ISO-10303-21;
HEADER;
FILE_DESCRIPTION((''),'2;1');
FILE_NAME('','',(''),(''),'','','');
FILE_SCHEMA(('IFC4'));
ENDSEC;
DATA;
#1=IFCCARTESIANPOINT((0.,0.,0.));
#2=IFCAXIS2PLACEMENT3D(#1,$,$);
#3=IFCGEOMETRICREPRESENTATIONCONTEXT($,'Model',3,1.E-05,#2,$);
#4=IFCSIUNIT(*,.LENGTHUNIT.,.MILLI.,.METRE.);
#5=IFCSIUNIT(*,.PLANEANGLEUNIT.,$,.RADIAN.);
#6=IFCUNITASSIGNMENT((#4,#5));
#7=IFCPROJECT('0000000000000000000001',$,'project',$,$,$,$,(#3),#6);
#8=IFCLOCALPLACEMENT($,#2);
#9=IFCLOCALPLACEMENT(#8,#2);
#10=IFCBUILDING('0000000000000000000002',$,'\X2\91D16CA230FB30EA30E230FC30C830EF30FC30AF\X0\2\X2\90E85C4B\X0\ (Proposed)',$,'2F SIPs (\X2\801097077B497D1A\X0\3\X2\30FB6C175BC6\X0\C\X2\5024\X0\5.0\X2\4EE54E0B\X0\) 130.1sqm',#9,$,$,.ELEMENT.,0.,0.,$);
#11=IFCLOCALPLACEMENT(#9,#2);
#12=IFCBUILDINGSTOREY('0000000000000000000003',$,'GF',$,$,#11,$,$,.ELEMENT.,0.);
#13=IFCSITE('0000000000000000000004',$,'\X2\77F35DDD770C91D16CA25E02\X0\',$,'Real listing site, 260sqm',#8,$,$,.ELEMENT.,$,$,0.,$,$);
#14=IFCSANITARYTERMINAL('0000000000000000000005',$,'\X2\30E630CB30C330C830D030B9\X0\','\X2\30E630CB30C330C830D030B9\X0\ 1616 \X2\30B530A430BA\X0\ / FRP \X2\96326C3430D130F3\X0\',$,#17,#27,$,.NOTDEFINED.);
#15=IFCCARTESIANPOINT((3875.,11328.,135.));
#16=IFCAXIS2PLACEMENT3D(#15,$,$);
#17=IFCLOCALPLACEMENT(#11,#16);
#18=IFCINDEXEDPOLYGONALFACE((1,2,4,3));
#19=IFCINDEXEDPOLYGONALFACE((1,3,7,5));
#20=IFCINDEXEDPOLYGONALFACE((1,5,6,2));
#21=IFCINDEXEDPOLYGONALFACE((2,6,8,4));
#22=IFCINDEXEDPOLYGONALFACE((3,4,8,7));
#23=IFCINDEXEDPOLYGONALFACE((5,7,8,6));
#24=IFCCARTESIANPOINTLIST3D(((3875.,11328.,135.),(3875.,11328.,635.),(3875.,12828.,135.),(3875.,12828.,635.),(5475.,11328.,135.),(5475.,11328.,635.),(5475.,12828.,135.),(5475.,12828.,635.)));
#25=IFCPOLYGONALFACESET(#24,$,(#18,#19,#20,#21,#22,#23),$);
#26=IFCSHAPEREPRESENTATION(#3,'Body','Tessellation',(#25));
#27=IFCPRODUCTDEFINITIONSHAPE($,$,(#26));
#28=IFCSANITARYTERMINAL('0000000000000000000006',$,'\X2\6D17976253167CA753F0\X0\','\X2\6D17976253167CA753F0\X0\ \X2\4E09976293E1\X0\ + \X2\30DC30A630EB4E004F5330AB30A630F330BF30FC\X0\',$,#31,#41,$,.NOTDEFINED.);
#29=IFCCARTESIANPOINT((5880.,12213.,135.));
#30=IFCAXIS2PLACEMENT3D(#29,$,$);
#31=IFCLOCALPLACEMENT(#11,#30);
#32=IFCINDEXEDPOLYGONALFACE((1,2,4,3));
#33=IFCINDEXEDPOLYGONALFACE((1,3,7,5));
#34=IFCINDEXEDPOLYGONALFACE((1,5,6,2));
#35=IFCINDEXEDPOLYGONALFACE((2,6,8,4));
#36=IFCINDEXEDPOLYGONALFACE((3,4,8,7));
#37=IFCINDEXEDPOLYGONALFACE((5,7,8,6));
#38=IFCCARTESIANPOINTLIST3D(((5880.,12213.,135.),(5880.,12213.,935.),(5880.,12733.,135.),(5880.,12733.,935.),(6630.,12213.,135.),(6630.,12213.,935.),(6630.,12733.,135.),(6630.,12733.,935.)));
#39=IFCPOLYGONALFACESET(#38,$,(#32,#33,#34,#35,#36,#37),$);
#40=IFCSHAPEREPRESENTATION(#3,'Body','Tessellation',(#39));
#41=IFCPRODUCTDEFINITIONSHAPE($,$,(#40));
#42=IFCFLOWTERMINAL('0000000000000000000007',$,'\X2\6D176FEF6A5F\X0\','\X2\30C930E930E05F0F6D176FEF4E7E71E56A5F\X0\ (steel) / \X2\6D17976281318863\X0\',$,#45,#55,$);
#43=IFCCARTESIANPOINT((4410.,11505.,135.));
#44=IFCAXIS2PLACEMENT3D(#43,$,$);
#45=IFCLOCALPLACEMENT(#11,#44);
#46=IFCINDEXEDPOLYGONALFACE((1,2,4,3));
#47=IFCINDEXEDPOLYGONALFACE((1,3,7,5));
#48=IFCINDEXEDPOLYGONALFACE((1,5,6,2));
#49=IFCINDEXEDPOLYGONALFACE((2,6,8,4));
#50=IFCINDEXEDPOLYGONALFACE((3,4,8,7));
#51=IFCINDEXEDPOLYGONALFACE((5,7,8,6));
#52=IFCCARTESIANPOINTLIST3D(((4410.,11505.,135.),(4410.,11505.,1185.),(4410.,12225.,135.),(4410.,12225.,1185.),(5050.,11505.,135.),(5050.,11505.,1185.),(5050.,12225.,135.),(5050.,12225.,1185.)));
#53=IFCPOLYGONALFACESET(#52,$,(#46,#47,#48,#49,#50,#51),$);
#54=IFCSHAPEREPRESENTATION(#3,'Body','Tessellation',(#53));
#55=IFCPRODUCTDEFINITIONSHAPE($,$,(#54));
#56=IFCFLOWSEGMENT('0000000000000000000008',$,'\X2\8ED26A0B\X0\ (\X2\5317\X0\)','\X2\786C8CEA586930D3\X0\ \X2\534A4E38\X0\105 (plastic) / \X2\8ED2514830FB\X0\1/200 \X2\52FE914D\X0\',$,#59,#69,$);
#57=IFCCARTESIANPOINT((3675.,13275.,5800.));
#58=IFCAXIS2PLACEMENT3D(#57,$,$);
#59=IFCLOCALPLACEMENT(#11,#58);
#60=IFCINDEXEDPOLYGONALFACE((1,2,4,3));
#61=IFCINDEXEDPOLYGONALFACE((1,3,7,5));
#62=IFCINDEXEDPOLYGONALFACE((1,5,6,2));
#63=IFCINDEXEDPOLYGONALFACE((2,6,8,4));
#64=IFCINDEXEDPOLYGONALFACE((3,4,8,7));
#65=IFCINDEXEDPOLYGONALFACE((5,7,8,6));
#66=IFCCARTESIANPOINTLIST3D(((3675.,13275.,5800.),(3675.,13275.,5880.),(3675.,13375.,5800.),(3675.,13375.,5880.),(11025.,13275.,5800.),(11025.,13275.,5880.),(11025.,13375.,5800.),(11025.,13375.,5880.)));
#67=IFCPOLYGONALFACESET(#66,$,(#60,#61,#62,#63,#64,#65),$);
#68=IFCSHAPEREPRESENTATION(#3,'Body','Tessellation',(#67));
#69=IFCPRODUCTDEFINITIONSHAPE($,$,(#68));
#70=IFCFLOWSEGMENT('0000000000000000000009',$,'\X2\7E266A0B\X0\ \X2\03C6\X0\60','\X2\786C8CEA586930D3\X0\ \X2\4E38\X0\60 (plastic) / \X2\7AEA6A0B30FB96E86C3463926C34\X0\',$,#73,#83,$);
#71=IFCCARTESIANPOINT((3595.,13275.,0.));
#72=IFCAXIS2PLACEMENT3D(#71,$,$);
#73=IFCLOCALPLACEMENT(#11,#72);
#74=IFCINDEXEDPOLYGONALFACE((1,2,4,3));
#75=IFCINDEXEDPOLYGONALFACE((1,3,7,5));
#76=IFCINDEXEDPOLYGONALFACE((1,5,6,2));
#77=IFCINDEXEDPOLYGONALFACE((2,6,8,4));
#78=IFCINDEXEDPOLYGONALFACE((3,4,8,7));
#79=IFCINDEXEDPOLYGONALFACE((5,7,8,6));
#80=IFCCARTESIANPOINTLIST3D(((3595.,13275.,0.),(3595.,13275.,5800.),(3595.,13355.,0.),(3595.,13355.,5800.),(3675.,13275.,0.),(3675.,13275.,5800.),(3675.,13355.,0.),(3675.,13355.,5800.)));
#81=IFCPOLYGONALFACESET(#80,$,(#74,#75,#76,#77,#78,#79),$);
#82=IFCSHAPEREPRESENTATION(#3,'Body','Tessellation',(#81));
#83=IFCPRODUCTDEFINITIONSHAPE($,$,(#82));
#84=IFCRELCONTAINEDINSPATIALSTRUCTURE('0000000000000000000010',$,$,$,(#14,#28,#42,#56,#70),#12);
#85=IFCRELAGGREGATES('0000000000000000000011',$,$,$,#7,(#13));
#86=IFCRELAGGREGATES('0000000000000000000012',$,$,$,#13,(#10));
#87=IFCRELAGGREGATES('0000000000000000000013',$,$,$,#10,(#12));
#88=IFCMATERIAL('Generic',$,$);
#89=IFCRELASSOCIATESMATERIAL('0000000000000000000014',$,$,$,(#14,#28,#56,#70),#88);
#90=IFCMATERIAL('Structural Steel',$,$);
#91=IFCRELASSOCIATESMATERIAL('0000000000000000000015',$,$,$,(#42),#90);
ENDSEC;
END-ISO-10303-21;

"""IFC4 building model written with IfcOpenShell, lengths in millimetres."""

from ifc_helpers import new_model, si_unit, frame, frame_2d, origin, place, context, project, spatial, rectangle, extrude, material, element, save


model = new_model("IFC4")

# Units and contexts
model_context = context("Model", 3, precision=1e-05, world=origin())
ifc_project = project(units=[si_unit("LENGTHUNIT", "METRE", prefix="MILLI"), si_unit("PLANEANGLEUNIT", "RADIAN")], contexts=[model_context])

# Site, building, storey
site_placement = place(None, origin())
site = spatial("IfcSite", under=ifc_project, at=site_placement, Name="石川県金沢市", ObjectType="Real listing site, 260sqm", CompositionType="ELEMENT", RefElevation=0.0)
building_placement = place(site_placement, origin())
building = spatial("IfcBuilding", under=site, at=building_placement, Name="金沢・リモートワーク2部屋 (Proposed)", ObjectType="2F SIPs (耐震等級3・気密C値5.0以下) 130.1sqm", CompositionType="ELEMENT", ElevationOfRefHeight=0.0, ElevationOfTerrain=0.0)
storey_placement = place(building_placement, origin())
storey = spatial("IfcBuildingStorey", under=building, at=storey_placement, Name="GF", CompositionType="ELEMENT", Elevation=0.0)

# Sanitary terminals
ifc_material_1 = material(Name="Generic")
sanitary_terminal_1_placement = place(storey_placement, frame((3875.0, 11328.0, 135.0)))
element("IfcSanitaryTerminal", 1, at=sanitary_terminal_1_placement, inside=storey, material=ifc_material_1, Name="ユニットバス", Description="ユニットバス 1616 サイズ / FRP 防水パン", PredefinedType="NOTDEFINED", context=model_context, shape_type="SweptSolid", body=[
    extrude(rectangle(XDim=1600.0, YDim=1500.0, at=frame_2d((800.0, 750.0))), frame((3875.0, 11328.0, 135.0)), (0.0, 0.0, 1.0), 500.0),
])
sanitary_terminal_2_placement = place(storey_placement, frame((5880.0, 12213.0, 135.0)))
element("IfcSanitaryTerminal", 2, at=sanitary_terminal_2_placement, inside=storey, material=ifc_material_1, Name="洗面化粧台", Description="洗面化粧台 三面鏡 + ボウル一体カウンター", PredefinedType="NOTDEFINED", context=model_context, shape_type="SweptSolid", body=[
    extrude(rectangle(XDim=750.0, YDim=520.0, at=frame_2d((375.0, 260.0))), frame((5880.0, 12213.0, 135.0)), (0.0, 0.0, 1.0), 800.0),
])

# Flow terminal
ifc_material_2 = material(Name="Structural Steel")
flow_terminal_placement = place(storey_placement, frame((4410.0, 11505.0, 135.0)))
element("IfcFlowTerminal", 3, at=flow_terminal_placement, inside=storey, material=ifc_material_2, Name="洗濯機", Description="ドラム式洗濯乾燥機 (steel) / 洗面脱衣", context=model_context, shape_type="SweptSolid", body=[
    extrude(rectangle(XDim=640.0, YDim=720.0, at=frame_2d((320.0, 360.0))), frame((4410.0, 11505.0, 135.0)), (0.0, 0.0, 1.0), 1050.0),
])

# Flow segments
flow_segment_1_placement = place(storey_placement, frame((3675.0, 13275.0, 5800.0)))
element("IfcFlowSegment", 4, at=flow_segment_1_placement, inside=storey, material=ifc_material_1, Name="軒樋 (北)", Description="硬質塩ビ 半丸105 (plastic) / 軒先・1/200 勾配", context=model_context, shape_type="SweptSolid", body=[
    extrude(rectangle(XDim=7350.0, YDim=100.0, at=frame_2d((3675.0, 50.0))), frame((3675.0, 13275.0, 5800.0)), (0.0, 0.0, 1.0), 80.0),
])
flow_segment_2_placement = place(storey_placement, frame((3595.0, 13275.0, 0.0)))
element("IfcFlowSegment", 5, at=flow_segment_2_placement, inside=storey, material=ifc_material_1, Name="縦樋 φ60", Description="硬質塩ビ 丸60 (plastic) / 竪樋・雨水排水", context=model_context, shape_type="SweptSolid", body=[
    extrude(rectangle(XDim=80.0, YDim=80.0, at=frame_2d((40.0, 40.0))), frame((3595.0, 13275.0, 0.0)), (0.0, 0.0, 1.0), 5800.0),
])

save(model, "model.ifc")
